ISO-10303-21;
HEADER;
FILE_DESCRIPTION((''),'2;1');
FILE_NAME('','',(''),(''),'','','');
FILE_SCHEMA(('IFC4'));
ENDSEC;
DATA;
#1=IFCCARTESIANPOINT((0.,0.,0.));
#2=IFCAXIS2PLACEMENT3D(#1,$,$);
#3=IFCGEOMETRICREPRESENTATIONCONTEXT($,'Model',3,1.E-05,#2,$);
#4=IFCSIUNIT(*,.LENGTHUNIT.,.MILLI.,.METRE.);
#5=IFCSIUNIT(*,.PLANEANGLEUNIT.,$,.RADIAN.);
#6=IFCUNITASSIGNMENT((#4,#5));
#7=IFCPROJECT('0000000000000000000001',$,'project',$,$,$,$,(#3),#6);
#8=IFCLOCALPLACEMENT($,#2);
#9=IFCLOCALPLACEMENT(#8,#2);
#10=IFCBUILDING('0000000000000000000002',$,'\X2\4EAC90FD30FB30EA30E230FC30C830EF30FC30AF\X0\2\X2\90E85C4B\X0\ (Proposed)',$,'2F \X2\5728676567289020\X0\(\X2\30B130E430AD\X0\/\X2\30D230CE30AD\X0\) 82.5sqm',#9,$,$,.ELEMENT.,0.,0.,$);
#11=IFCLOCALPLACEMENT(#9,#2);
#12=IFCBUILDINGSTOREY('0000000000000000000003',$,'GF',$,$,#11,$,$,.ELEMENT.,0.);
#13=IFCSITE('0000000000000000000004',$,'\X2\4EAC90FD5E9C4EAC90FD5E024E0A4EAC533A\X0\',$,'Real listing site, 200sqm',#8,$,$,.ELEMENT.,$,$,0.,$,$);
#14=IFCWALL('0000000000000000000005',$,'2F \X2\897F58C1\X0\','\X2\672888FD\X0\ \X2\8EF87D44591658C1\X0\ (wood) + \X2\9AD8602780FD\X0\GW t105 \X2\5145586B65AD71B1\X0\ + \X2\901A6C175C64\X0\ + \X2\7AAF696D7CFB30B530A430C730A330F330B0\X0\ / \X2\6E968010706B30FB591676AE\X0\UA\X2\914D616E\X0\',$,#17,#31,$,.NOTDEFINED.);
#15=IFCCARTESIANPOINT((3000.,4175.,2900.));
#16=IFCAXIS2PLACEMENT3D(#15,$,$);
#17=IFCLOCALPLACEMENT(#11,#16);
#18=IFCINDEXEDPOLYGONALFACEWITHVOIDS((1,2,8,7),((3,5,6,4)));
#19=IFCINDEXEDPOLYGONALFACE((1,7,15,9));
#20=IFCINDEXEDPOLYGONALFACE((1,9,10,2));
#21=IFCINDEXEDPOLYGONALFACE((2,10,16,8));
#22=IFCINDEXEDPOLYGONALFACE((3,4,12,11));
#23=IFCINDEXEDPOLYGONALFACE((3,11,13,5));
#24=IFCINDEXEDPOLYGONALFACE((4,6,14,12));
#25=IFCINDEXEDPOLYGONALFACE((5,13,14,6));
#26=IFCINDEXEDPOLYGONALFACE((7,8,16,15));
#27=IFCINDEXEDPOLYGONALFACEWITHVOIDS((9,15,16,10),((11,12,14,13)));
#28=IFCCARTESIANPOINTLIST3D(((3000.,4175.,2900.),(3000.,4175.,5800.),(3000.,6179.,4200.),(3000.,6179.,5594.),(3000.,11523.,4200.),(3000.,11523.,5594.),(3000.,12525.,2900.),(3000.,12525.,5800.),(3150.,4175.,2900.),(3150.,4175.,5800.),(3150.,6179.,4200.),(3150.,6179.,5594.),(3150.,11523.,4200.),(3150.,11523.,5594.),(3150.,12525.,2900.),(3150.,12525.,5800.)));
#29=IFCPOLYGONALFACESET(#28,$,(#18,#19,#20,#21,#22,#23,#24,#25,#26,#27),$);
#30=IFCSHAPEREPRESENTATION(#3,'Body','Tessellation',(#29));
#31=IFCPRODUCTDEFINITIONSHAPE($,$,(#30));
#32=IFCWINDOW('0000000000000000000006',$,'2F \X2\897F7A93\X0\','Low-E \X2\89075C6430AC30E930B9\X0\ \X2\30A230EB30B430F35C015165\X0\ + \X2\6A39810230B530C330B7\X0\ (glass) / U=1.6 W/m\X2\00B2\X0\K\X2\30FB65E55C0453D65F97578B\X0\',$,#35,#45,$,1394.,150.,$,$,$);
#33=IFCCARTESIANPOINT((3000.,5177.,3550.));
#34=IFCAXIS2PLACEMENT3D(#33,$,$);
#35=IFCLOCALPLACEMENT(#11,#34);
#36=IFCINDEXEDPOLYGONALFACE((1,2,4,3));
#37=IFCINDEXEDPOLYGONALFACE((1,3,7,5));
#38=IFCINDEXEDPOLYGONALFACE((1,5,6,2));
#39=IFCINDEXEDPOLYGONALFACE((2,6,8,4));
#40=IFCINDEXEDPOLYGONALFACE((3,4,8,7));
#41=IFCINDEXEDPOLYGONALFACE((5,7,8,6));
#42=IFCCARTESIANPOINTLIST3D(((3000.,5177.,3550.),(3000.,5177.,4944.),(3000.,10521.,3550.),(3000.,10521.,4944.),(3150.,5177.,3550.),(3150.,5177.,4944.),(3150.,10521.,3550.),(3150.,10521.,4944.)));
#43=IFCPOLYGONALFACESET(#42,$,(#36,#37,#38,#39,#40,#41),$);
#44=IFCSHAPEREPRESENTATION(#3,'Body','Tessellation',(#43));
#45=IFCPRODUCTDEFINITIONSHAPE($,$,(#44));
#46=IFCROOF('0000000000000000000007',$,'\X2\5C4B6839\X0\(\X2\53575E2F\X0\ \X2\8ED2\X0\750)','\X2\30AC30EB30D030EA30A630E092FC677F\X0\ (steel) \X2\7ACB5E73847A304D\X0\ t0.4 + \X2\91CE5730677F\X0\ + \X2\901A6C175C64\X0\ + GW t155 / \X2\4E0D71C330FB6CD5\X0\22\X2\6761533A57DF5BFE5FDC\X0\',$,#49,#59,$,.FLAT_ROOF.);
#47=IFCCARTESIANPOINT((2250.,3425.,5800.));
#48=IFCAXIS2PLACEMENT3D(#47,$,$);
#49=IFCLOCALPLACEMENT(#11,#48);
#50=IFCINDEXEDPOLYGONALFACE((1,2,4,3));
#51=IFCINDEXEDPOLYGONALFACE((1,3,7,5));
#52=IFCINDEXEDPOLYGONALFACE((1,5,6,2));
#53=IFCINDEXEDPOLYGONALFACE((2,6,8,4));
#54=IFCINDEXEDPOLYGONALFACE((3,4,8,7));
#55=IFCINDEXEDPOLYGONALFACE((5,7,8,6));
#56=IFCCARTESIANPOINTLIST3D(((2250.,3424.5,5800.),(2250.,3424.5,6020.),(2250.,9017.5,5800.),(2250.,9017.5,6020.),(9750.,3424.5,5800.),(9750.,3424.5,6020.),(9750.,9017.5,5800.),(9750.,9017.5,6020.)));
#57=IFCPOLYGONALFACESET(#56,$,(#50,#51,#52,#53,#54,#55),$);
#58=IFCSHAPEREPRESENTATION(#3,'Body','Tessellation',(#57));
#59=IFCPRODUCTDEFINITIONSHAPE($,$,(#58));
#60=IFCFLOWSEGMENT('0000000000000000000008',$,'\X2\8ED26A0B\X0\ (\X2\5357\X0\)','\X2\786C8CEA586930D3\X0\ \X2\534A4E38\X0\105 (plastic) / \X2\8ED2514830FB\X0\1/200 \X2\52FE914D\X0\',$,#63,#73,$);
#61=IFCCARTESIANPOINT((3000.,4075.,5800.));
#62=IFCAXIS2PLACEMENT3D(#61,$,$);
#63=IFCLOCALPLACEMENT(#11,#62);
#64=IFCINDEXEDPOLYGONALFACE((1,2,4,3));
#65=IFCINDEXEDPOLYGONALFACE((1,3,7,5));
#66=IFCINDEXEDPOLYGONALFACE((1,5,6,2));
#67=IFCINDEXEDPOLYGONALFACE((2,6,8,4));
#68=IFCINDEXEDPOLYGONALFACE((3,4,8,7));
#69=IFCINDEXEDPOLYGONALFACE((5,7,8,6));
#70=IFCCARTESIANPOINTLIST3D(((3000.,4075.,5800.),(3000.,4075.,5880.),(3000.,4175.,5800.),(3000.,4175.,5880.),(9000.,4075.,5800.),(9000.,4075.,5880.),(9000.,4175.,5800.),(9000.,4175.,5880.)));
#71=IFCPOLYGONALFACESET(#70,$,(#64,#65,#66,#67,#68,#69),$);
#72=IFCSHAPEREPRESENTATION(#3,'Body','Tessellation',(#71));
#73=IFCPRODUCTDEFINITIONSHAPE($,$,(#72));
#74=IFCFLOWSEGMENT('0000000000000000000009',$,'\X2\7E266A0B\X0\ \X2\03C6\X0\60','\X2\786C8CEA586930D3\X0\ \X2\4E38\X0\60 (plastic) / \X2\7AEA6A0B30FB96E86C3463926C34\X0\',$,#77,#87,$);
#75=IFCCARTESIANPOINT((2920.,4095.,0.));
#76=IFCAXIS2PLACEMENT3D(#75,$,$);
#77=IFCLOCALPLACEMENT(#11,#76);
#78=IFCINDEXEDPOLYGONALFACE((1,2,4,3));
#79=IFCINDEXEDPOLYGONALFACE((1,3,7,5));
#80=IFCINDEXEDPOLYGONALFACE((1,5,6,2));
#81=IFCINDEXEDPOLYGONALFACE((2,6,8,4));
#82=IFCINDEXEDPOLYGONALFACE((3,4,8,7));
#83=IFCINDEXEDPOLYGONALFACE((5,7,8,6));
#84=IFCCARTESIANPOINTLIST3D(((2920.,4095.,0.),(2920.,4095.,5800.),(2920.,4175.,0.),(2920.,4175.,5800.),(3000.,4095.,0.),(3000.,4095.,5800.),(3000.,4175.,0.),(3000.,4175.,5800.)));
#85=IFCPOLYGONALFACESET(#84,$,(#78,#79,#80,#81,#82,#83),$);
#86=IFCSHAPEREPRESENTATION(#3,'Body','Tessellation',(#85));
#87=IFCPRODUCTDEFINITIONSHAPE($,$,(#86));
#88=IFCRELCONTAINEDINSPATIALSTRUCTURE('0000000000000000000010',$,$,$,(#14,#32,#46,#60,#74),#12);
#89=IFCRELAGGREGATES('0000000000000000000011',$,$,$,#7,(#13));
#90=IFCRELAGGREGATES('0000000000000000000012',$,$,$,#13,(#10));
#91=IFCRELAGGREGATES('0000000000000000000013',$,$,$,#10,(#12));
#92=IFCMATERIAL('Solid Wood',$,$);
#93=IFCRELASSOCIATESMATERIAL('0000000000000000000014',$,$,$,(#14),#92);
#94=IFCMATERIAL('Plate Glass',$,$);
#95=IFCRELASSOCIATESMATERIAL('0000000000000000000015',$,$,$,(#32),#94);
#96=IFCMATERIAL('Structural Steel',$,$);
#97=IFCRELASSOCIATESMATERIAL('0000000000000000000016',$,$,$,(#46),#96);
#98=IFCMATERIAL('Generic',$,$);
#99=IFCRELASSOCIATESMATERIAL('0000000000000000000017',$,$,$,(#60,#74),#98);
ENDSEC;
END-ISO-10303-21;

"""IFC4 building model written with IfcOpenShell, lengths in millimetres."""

from ifc_helpers import new_model, si_unit, frame, frame_2d, origin, place, context, project, spatial, rectangle, extrude, material, element, fill, save


model = new_model("IFC4")

# Units and contexts
model_context = context("Model", 3, precision=1e-05, world=origin())
ifc_project = project(units=[si_unit("LENGTHUNIT", "METRE", prefix="MILLI"), si_unit("PLANEANGLEUNIT", "RADIAN")], contexts=[model_context])

# Site, building, storey
site_placement = place(None, origin())
site = spatial("IfcSite", under=ifc_project, at=site_placement, Name="京都府京都市上京区", ObjectType="Real listing site, 200sqm", CompositionType="ELEMENT", RefElevation=0.0)
building_placement = place(site_placement, origin())
building = spatial("IfcBuilding", under=site, at=building_placement, Name="京都・リモートワーク2部屋 (Proposed)", ObjectType="2F 在来木造(ケヤキ/ヒノキ) 82.5sqm", CompositionType="ELEMENT", ElevationOfRefHeight=0.0, ElevationOfTerrain=0.0)
storey_placement = place(building_placement, origin())
storey = spatial("IfcBuildingStorey", under=building, at=storey_placement, Name="GF", CompositionType="ELEMENT", Elevation=0.0)

# Shared definitions
ifc_material_1 = material(Name="Solid Wood")

# Shared definitions
ifc_material_2 = material(Name="Plate Glass")

# Wall, opening, window
wall_1_placement = place(storey_placement, frame((3000.0, 4175.0, 2900.0)))
wall_1 = element("IfcWall", 1, at=wall_1_placement, inside=storey, material=ifc_material_1, Name="2F 西壁", Description="木製 軸組外壁 (wood) + 高性能GW t105 充填断熱 + 通気層 + 窯業系サイディング / 準耐火・外皮UA配慮", PredefinedType="NOTDEFINED", context=model_context, shape_type="SweptSolid", body=[
    extrude(rectangle(XDim=150.0, YDim=8350.0, at=frame_2d((75.0, 4175.0))), frame((3000.0, 4175.0, 2900.0)), (0.0, 0.0, 1.0), 2900.0),
])
opening_1_placement = place(storey_placement, frame((3000.0, 5177.0, 3550.0)))
opening_1 = element("IfcOpeningElement", 2, at=opening_1_placement, cuts=wall_1, PredefinedType="NOTDEFINED", context=model_context, shape_type="SweptSolid", body=[
    extrude(rectangle(XDim=150.0, YDim=5344.0, at=frame_2d((75.0, 2672.0))), frame((3000.0, 5177.0, 3550.0)), (0.0, 0.0, 1.0), 1394.0),
])
window_1_placement = place(storey_placement, frame((3000.0, 5177.0, 3550.0)))
window_1 = element("IfcWindow", 3, at=window_1_placement, inside=storey, material=ifc_material_2, Name="2F 西窓", Description="Low-E 複層ガラス アルゴン封入 + 樹脂サッシ (glass) / U=1.6 W/m²K・日射取得型", OverallHeight=1394.0, OverallWidth=150.0, context=model_context, shape_type="SweptSolid", body=[
    extrude(rectangle(XDim=150.0, YDim=5344.0, at=frame_2d((75.0, 2672.0))), frame((3000.0, 5177.0, 3550.0)), (0.0, 0.0, 1.0), 1394.0),
])
fill(opening_1, window_1)

# Roof
ifc_material_3 = material(Name="Structural Steel")
for number, where, name in (
    (4, (2250.0, 3425.0, 5800.0), "屋根(南帯 軒750)"),
):
    element("IfcRoof", number, at=place(storey_placement, frame(where)), inside=storey, material=ifc_material_3, Name=name, Description="ガルバリウム鋼板 (steel) 立平葺き t0.4 + 野地板 + 通気層 + GW t155 / 不燃・法22条区域対応", PredefinedType="FLAT_ROOF", context=model_context, shape_type="SweptSolid", body=[
        extrude(rectangle(XDim=7500.0, YDim=5593.0, at=frame_2d((3750.0, 2796.0))), frame((2250.0, 3425.0, 5800.0)), (0.0, 0.0, 1.0), 220.0),
    ])

# Flow segments
ifc_material_4 = material(Name="Generic")
flow_segment_1_placement = place(storey_placement, frame((3000.0, 4075.0, 5800.0)))
element("IfcFlowSegment", 5, at=flow_segment_1_placement, inside=storey, material=ifc_material_4, Name="軒樋 (南)", Description="硬質塩ビ 半丸105 (plastic) / 軒先・1/200 勾配", context=model_context, shape_type="SweptSolid", body=[
    extrude(rectangle(XDim=6000.0, YDim=100.0, at=frame_2d((3000.0, 50.0))), frame((3000.0, 4075.0, 5800.0)), (0.0, 0.0, 1.0), 80.0),
])
flow_segment_2_placement = place(storey_placement, frame((2920.0, 4095.0, 0.0)))
element("IfcFlowSegment", 6, at=flow_segment_2_placement, inside=storey, material=ifc_material_4, Name="縦樋 φ60", Description="硬質塩ビ 丸60 (plastic) / 竪樋・雨水排水", context=model_context, shape_type="SweptSolid", body=[
    extrude(rectangle(XDim=80.0, YDim=80.0, at=frame_2d((40.0, 40.0))), frame((2920.0, 4095.0, 0.0)), (0.0, 0.0, 1.0), 5800.0),
])

save(model, "model.ifc")
